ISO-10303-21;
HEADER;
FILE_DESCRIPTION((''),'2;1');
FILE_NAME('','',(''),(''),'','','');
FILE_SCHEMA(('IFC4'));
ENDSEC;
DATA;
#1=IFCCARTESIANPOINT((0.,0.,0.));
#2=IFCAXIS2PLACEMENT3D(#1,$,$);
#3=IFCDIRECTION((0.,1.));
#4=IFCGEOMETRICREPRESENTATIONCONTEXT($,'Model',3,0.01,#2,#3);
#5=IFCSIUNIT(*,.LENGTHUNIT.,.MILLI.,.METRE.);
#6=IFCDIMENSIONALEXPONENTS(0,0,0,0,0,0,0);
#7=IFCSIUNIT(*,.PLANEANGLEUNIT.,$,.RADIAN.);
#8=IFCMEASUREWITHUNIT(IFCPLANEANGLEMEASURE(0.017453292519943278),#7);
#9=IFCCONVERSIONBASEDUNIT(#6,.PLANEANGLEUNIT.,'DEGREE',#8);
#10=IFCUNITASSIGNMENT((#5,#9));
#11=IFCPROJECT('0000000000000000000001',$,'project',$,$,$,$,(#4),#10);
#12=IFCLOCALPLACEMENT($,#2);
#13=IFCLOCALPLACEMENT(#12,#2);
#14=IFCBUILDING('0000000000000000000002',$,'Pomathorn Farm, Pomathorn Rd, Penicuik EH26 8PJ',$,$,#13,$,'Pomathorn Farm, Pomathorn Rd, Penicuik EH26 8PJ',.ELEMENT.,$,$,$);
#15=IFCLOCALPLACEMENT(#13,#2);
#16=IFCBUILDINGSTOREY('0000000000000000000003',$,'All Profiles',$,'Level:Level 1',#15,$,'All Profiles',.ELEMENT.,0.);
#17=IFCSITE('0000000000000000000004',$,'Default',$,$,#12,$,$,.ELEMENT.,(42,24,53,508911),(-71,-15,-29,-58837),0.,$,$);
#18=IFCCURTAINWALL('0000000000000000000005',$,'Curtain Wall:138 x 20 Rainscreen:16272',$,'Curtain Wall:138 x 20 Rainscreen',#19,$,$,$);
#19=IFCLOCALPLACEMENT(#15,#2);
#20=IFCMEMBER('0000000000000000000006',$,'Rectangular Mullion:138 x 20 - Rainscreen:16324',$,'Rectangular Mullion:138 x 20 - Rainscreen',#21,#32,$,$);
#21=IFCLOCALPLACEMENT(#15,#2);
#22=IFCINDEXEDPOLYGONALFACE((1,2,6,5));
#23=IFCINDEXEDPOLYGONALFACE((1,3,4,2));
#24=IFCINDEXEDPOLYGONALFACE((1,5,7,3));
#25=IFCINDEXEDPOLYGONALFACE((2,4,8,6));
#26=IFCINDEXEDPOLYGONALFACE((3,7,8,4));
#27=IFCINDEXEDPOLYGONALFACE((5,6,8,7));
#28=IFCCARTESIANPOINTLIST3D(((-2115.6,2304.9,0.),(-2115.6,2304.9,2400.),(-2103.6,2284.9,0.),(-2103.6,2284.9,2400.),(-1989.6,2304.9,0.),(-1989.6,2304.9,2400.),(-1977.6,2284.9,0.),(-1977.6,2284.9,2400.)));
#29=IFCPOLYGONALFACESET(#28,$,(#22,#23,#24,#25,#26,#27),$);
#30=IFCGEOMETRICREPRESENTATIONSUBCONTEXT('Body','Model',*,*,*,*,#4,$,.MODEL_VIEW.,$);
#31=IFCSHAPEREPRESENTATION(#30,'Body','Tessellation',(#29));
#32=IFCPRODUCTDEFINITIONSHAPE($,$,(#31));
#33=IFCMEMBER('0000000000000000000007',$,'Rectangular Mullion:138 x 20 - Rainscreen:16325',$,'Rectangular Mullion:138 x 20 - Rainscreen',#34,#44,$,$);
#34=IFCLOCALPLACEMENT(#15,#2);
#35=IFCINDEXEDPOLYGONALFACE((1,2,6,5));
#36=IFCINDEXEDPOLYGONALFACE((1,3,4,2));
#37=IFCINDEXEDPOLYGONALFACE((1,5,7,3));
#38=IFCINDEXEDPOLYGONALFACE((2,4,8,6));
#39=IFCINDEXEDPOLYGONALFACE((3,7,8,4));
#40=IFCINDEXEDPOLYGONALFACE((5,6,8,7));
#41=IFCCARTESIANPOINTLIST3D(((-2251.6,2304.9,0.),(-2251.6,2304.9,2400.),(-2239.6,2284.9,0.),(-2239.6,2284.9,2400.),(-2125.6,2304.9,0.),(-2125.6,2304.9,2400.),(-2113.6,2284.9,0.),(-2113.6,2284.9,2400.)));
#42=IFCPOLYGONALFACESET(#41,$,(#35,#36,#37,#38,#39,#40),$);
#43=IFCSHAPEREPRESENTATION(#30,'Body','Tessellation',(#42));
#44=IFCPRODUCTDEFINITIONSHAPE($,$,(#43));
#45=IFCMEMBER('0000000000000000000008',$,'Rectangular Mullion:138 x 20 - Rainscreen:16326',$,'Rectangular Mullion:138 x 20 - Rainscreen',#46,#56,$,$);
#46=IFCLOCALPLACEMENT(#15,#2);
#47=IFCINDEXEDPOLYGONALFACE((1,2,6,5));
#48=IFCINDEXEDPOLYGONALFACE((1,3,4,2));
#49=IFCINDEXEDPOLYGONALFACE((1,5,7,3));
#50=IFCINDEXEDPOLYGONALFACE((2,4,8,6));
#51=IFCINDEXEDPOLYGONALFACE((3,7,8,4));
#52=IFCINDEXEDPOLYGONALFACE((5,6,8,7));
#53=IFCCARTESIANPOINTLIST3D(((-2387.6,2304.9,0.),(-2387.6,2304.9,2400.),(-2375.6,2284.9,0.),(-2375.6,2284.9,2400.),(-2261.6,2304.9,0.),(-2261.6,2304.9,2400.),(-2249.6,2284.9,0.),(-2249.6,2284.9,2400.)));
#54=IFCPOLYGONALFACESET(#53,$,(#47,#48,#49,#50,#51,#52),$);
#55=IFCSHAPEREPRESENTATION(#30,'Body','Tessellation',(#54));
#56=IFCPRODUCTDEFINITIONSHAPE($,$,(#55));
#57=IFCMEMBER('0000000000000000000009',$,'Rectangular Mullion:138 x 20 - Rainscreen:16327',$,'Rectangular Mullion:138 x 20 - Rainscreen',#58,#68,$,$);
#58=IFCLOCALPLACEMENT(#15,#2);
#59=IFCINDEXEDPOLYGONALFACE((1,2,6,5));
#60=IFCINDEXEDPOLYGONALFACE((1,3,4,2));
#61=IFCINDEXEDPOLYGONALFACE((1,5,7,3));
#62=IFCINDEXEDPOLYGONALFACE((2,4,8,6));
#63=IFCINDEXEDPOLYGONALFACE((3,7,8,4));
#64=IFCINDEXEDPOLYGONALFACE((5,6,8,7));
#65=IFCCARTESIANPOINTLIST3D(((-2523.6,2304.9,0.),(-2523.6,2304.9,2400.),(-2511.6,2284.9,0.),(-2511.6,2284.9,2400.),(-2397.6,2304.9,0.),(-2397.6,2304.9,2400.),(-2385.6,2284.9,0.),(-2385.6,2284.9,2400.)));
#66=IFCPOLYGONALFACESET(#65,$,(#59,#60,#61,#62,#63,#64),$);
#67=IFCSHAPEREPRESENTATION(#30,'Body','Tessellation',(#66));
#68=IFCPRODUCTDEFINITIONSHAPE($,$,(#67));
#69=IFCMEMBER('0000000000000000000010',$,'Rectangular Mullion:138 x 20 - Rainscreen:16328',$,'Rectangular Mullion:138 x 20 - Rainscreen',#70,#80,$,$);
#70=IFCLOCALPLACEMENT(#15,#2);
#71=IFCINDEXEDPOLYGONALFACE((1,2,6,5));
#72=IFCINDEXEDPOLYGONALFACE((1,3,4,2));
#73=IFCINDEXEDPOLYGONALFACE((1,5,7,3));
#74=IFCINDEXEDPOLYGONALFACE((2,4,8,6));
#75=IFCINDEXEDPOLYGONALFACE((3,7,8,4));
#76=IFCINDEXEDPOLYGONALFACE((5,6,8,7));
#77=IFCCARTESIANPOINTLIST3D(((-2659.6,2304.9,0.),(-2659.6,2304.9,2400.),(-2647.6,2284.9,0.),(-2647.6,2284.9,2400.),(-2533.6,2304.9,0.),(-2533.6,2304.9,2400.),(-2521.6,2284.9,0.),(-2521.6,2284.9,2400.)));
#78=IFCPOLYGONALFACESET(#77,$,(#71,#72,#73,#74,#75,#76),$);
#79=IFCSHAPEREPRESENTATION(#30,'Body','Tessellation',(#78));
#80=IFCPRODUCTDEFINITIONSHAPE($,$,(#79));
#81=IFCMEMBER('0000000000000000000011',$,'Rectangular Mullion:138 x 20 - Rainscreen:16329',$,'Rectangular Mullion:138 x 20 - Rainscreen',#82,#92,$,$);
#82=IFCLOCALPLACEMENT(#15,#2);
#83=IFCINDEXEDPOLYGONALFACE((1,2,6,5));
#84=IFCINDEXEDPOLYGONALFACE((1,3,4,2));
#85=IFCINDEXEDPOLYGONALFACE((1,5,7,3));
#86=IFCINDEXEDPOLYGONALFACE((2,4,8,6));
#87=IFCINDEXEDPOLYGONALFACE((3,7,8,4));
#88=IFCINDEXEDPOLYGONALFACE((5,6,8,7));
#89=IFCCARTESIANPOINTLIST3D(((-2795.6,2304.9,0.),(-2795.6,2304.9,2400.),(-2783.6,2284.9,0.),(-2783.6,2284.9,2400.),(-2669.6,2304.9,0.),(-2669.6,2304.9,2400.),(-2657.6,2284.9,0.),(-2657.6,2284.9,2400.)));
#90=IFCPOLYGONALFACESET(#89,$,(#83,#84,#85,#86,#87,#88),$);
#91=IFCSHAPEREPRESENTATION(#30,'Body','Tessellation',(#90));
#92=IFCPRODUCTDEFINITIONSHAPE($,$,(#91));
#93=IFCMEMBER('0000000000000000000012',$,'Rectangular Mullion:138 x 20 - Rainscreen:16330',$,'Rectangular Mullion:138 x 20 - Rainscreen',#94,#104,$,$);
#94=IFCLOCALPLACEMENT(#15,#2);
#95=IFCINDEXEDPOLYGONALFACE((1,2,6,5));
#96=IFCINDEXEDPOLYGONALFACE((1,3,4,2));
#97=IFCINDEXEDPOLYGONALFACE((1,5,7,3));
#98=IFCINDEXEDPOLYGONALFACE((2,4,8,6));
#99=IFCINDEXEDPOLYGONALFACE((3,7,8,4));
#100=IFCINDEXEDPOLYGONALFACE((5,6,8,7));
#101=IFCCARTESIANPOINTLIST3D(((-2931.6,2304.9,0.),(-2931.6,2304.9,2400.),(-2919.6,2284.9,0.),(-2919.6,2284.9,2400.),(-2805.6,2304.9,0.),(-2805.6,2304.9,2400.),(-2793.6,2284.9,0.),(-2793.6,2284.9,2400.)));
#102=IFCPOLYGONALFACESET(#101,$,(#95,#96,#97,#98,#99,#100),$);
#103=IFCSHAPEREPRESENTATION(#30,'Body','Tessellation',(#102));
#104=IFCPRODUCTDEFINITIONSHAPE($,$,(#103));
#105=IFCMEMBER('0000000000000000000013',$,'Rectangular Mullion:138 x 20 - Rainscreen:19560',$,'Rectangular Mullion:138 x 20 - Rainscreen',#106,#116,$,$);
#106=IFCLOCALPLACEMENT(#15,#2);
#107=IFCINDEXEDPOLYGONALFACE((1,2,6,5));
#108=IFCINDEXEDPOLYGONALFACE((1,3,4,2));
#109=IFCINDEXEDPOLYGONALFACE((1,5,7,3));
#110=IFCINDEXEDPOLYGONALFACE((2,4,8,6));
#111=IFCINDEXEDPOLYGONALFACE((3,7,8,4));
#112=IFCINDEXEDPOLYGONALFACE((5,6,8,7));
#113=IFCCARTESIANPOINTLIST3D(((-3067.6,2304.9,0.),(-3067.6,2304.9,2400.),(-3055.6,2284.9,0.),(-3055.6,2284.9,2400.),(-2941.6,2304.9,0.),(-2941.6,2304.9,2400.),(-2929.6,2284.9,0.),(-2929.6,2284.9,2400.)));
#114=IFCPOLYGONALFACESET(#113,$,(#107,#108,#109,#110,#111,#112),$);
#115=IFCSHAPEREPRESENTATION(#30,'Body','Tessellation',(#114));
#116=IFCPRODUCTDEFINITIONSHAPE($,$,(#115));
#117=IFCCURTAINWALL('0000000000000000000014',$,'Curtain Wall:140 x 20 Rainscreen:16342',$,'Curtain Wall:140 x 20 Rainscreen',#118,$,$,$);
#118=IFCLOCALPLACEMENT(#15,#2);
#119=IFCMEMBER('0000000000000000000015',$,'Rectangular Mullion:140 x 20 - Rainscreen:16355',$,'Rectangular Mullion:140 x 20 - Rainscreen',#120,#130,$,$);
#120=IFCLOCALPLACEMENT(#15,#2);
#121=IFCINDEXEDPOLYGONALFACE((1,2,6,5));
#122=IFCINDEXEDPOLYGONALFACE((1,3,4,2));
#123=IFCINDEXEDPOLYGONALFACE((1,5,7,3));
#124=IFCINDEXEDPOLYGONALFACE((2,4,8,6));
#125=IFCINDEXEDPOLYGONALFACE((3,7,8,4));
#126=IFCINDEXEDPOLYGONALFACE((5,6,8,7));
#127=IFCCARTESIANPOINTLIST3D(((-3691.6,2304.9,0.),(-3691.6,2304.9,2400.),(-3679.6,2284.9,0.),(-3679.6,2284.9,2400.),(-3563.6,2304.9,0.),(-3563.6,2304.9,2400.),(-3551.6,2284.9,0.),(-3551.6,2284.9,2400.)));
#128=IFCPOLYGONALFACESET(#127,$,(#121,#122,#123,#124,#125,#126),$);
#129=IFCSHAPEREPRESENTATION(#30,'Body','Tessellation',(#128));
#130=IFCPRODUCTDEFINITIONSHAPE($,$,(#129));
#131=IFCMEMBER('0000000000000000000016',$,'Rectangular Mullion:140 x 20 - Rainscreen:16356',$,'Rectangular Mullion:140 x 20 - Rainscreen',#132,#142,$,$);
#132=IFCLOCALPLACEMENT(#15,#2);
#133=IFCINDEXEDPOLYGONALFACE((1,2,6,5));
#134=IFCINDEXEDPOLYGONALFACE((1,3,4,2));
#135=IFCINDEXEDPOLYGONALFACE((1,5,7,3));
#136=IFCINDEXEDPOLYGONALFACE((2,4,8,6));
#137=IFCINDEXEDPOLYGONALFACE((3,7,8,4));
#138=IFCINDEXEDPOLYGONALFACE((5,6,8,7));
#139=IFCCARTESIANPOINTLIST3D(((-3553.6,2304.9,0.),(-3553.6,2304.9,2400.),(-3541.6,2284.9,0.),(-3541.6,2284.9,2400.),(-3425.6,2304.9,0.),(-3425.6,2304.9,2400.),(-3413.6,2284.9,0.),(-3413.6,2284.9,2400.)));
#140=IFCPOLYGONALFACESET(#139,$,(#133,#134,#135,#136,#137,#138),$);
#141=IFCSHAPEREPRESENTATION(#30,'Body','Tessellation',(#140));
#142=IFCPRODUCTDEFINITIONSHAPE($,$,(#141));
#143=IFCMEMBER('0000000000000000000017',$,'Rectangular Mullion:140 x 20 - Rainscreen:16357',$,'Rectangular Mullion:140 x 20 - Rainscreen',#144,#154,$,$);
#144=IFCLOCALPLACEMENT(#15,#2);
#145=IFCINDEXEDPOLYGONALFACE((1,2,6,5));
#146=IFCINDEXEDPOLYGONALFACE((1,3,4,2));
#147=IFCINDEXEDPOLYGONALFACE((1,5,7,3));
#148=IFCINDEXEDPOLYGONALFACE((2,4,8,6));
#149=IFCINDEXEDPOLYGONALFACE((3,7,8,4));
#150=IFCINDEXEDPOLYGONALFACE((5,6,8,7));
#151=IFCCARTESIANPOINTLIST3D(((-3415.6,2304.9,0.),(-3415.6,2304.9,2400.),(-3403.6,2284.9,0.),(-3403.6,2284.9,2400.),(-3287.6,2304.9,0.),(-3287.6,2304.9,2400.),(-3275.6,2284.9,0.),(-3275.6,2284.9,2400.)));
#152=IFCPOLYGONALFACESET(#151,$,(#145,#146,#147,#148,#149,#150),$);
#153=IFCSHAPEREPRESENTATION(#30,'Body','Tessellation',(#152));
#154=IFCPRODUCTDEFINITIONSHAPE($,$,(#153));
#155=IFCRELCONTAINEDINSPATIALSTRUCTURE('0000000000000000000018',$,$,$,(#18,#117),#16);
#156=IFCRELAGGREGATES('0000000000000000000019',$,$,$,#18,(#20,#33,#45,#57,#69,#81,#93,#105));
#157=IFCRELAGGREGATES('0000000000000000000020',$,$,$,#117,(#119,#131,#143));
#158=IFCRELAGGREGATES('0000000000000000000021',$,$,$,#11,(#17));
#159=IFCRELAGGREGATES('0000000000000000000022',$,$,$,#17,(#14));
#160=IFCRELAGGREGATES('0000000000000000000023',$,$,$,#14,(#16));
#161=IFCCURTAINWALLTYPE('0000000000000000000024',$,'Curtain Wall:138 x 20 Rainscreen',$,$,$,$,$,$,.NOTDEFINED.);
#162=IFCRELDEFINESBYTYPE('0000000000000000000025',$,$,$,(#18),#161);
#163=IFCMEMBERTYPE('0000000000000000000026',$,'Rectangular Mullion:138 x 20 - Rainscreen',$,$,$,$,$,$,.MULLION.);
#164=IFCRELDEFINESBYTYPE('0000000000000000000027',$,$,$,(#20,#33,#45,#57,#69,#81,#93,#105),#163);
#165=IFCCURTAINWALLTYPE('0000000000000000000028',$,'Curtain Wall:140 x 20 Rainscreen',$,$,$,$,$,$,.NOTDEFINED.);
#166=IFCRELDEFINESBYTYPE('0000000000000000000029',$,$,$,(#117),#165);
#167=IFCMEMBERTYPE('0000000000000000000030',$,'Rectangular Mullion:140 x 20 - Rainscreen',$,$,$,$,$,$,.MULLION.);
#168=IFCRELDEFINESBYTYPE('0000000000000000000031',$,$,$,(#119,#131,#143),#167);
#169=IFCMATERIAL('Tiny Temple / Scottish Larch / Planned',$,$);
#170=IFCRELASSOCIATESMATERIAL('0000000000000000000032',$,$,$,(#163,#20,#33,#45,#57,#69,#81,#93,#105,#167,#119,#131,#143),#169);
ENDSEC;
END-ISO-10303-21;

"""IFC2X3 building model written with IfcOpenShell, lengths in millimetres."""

from ifc_helpers import new_model, entity, si_unit, converted_unit, direction, frame, origin, place, context, subcontext, project, spatial, polyline, outline, extrude, source, transform, mapped, material, type_object, type_shapes, element, aggregate, save


model = new_model("IFC2X3")

# Units and contexts
model_context = context("Model", 3, precision=0.01, world=origin(), true_north=direction((0.0, 1.0)))
body_context = subcontext(model_context, "Body", "Model", "MODEL_VIEW")
ifc_project = project(units=[si_unit("LENGTHUNIT", "METRE", prefix="MILLI"), converted_unit("PLANEANGLEUNIT", "DEGREE", entity("IfcPlaneAngleMeasure", 0.017453292519943278), si_unit("PLANEANGLEUNIT", "RADIAN"), dimensions=[0, 0, 0, 0, 0, 0, 0])], contexts=[model_context])

# Site, building, storey
site_placement = place(None, origin())
site = spatial("IfcSite", under=ifc_project, at=site_placement, Name="Default", CompositionType="ELEMENT", RefLatitude=(42, 24, 53, 508911), RefLongitude=(-71, -15, -29, -58837), RefElevation=0.0)
building_placement = place(site_placement, origin())
building = spatial("IfcBuilding", under=site, at=building_placement, Name="Pomathorn Farm, Pomathorn Rd, Penicuik EH26 8PJ", LongName="Pomathorn Farm, Pomathorn Rd, Penicuik EH26 8PJ", CompositionType="ELEMENT")
storey_placement = place(building_placement, origin())
storey = spatial("IfcBuildingStorey", under=building, at=storey_placement, Name="All Profiles", ObjectType="Level:Level 1", LongName="All Profiles", CompositionType="ELEMENT", Elevation=0.0)

# Curtain walls, members
ifc_material = material(Name="Tiny Temple / Scottish Larch / Planned")
curtain_wall_type_1 = type_object("IfcCurtainWallType", Name="Curtain Wall:138 x 20 Rainscreen", PredefinedType="NOTDEFINED")
curtain_wall_1_placement = place(storey_placement, origin())
curtain_wall_1 = element("IfcCurtainWall", 1, at=curtain_wall_1_placement, inside=storey, type_object=curtain_wall_type_1, Name="Curtain Wall:138 x 20 Rainscreen:16272", ObjectType="Curtain Wall:138 x 20 Rainscreen")
member_type_1 = type_object("IfcMemberType", Name="Rectangular Mullion:138 x 20 - Rainscreen", PredefinedType="MULLION", material=ifc_material)
shared_shape_1 = source(origin(), body_context, "Body", "SweptSolid", [
    extrude(outline(polyline([(20.8, -54.0), (44.1, -54.0), (-20.8, 54.0), (-44.1, 54.0), (20.8, -54.0)])), frame((-69.0, -10.0, -2400.0), z_axis=(0.0, 0.0, 1.0), x_axis=(0.514496, 0.857493, 0.0)), (0.0, 0.0, 1.0), 2400.0),
])
type_shapes(member_type_1, [shared_shape_1])
member_1_placement = place(curtain_wall_1_placement, frame((-1977.6, 2284.9, 0.0), z_axis=(0.0, 0.0, -1.0), x_axis=(1.0, 0.0, 0.0)))
member_1 = element("IfcMember", 2, at=member_1_placement, type_object=member_type_1, material=ifc_material, Name="Rectangular Mullion:138 x 20 - Rainscreen:16324", ObjectType="Rectangular Mullion:138 x 20 - Rainscreen", context=body_context, shape_type="MappedRepresentation", body=[
    mapped(shared_shape_1, transform((0.0, 0.0, 0.0), scale=1.0)),
])
member_2_placement = place(curtain_wall_1_placement, frame((-2113.6, 2284.9, 0.0), z_axis=(0.0, 0.0, -1.0), x_axis=(1.0, 0.0, 0.0)))
member_2 = element("IfcMember", 3, at=member_2_placement, type_object=member_type_1, material=ifc_material, Name="Rectangular Mullion:138 x 20 - Rainscreen:16325", ObjectType="Rectangular Mullion:138 x 20 - Rainscreen", context=body_context, shape_type="MappedRepresentation", body=[
    mapped(shared_shape_1, transform((0.0, 0.0, 0.0), scale=1.0)),
])
member_3_placement = place(curtain_wall_1_placement, frame((-2249.6, 2284.9, 0.0), z_axis=(0.0, 0.0, -1.0), x_axis=(1.0, 0.0, 0.0)))
member_3 = element("IfcMember", 4, at=member_3_placement, type_object=member_type_1, material=ifc_material, Name="Rectangular Mullion:138 x 20 - Rainscreen:16326", ObjectType="Rectangular Mullion:138 x 20 - Rainscreen", context=body_context, shape_type="MappedRepresentation", body=[
    mapped(shared_shape_1, transform((0.0, 0.0, 0.0), scale=1.0)),
])
member_4_placement = place(curtain_wall_1_placement, frame((-2385.6, 2284.9, 0.0), z_axis=(0.0, 0.0, -1.0), x_axis=(1.0, 0.0, 0.0)))
member_4 = element("IfcMember", 5, at=member_4_placement, type_object=member_type_1, material=ifc_material, Name="Rectangular Mullion:138 x 20 - Rainscreen:16327", ObjectType="Rectangular Mullion:138 x 20 - Rainscreen", context=body_context, shape_type="MappedRepresentation", body=[
    mapped(shared_shape_1, transform((0.0, 0.0, 0.0), scale=1.0)),
])
member_5_placement = place(curtain_wall_1_placement, frame((-2521.6, 2284.9, 0.0), z_axis=(0.0, 0.0, -1.0), x_axis=(1.0, 0.0, 0.0)))
member_5 = element("IfcMember", 6, at=member_5_placement, type_object=member_type_1, material=ifc_material, Name="Rectangular Mullion:138 x 20 - Rainscreen:16328", ObjectType="Rectangular Mullion:138 x 20 - Rainscreen", context=body_context, shape_type="MappedRepresentation", body=[
    mapped(shared_shape_1, transform((0.0, 0.0, 0.0), scale=1.0)),
])
member_6_placement = place(curtain_wall_1_placement, frame((-2657.6, 2284.9, 0.0), z_axis=(0.0, 0.0, -1.0), x_axis=(1.0, 0.0, 0.0)))
member_6 = element("IfcMember", 7, at=member_6_placement, type_object=member_type_1, material=ifc_material, Name="Rectangular Mullion:138 x 20 - Rainscreen:16329", ObjectType="Rectangular Mullion:138 x 20 - Rainscreen", context=body_context, shape_type="MappedRepresentation", body=[
    mapped(shared_shape_1, transform((0.0, 0.0, 0.0), scale=1.0)),
])
member_7_placement = place(curtain_wall_1_placement, frame((-2793.6, 2284.9, 0.0), z_axis=(0.0, 0.0, -1.0), x_axis=(1.0, 0.0, 0.0)))
member_7 = element("IfcMember", 8, at=member_7_placement, type_object=member_type_1, material=ifc_material, Name="Rectangular Mullion:138 x 20 - Rainscreen:16330", ObjectType="Rectangular Mullion:138 x 20 - Rainscreen", context=body_context, shape_type="MappedRepresentation", body=[
    mapped(shared_shape_1, transform((0.0, 0.0, 0.0), scale=1.0)),
])
member_8_placement = place(curtain_wall_1_placement, frame((-2929.6, 2284.9, 0.0), z_axis=(0.0, 0.0, -1.0), x_axis=(1.0, 0.0, 0.0)))
member_8 = element("IfcMember", 9, at=member_8_placement, type_object=member_type_1, material=ifc_material, Name="Rectangular Mullion:138 x 20 - Rainscreen:19560", ObjectType="Rectangular Mullion:138 x 20 - Rainscreen", context=body_context, shape_type="MappedRepresentation", body=[
    mapped(shared_shape_1, transform((0.0, 0.0, 0.0), scale=1.0)),
])
aggregate(curtain_wall_1, [member_1, member_2, member_3, member_4, member_5, member_6, member_7, member_8])
curtain_wall_type_2 = type_object("IfcCurtainWallType", Name="Curtain Wall:140 x 20 Rainscreen", PredefinedType="NOTDEFINED")
curtain_wall_2_placement = place(storey_placement, origin())
curtain_wall_2 = element("IfcCurtainWall", 10, at=curtain_wall_2_placement, inside=storey, type_object=curtain_wall_type_2, Name="Curtain Wall:140 x 20 Rainscreen:16342", ObjectType="Curtain Wall:140 x 20 Rainscreen")
member_type_2 = type_object("IfcMemberType", Name="Rectangular Mullion:140 x 20 - Rainscreen", PredefinedType="MULLION", material=ifc_material)
shared_shape_2 = source(origin(), body_context, "Body", "SweptSolid", [
    extrude(outline(polyline([(21.3, -54.9), (44.6, -54.9), (-21.3, 54.9), (-44.6, 54.9), (21.3, -54.9)])), frame((-70.0, -10.0, -2400.0), z_axis=(0.0, 0.0, 1.0), x_axis=(0.514496, 0.857493, 0.0)), (0.0, 0.0, 1.0), 2400.0),
])
type_shapes(member_type_2, [shared_shape_2])
member_9_placement = place(curtain_wall_2_placement, frame((-3551.6, 2284.9, 0.0), z_axis=(0.0, 0.0, -1.0), x_axis=(1.0, 0.0, 0.0)))
member_9 = element("IfcMember", 11, at=member_9_placement, type_object=member_type_2, material=ifc_material, Name="Rectangular Mullion:140 x 20 - Rainscreen:16355", ObjectType="Rectangular Mullion:140 x 20 - Rainscreen", context=body_context, shape_type="MappedRepresentation", body=[
    mapped(shared_shape_2, transform((0.0, 0.0, 0.0), scale=1.0)),
])
member_10_placement = place(curtain_wall_2_placement, frame((-3413.6, 2284.9, 0.0), z_axis=(0.0, 0.0, -1.0), x_axis=(1.0, 0.0, 0.0)))
member_10 = element("IfcMember", 12, at=member_10_placement, type_object=member_type_2, material=ifc_material, Name="Rectangular Mullion:140 x 20 - Rainscreen:16356", ObjectType="Rectangular Mullion:140 x 20 - Rainscreen", context=body_context, shape_type="MappedRepresentation", body=[
    mapped(shared_shape_2, transform((0.0, 0.0, 0.0), scale=1.0)),
])
member_11_placement = place(curtain_wall_2_placement, frame((-3275.6, 2284.9, 0.0), z_axis=(0.0, 0.0, -1.0), x_axis=(1.0, 0.0, 0.0)))
member_11 = element("IfcMember", 13, at=member_11_placement, type_object=member_type_2, material=ifc_material, Name="Rectangular Mullion:140 x 20 - Rainscreen:16357", ObjectType="Rectangular Mullion:140 x 20 - Rainscreen", context=body_context, shape_type="MappedRepresentation", body=[
    mapped(shared_shape_2, transform((0.0, 0.0, 0.0), scale=1.0)),
])
aggregate(curtain_wall_2, [member_9, member_10, member_11])

save(model, "model.ifc")
